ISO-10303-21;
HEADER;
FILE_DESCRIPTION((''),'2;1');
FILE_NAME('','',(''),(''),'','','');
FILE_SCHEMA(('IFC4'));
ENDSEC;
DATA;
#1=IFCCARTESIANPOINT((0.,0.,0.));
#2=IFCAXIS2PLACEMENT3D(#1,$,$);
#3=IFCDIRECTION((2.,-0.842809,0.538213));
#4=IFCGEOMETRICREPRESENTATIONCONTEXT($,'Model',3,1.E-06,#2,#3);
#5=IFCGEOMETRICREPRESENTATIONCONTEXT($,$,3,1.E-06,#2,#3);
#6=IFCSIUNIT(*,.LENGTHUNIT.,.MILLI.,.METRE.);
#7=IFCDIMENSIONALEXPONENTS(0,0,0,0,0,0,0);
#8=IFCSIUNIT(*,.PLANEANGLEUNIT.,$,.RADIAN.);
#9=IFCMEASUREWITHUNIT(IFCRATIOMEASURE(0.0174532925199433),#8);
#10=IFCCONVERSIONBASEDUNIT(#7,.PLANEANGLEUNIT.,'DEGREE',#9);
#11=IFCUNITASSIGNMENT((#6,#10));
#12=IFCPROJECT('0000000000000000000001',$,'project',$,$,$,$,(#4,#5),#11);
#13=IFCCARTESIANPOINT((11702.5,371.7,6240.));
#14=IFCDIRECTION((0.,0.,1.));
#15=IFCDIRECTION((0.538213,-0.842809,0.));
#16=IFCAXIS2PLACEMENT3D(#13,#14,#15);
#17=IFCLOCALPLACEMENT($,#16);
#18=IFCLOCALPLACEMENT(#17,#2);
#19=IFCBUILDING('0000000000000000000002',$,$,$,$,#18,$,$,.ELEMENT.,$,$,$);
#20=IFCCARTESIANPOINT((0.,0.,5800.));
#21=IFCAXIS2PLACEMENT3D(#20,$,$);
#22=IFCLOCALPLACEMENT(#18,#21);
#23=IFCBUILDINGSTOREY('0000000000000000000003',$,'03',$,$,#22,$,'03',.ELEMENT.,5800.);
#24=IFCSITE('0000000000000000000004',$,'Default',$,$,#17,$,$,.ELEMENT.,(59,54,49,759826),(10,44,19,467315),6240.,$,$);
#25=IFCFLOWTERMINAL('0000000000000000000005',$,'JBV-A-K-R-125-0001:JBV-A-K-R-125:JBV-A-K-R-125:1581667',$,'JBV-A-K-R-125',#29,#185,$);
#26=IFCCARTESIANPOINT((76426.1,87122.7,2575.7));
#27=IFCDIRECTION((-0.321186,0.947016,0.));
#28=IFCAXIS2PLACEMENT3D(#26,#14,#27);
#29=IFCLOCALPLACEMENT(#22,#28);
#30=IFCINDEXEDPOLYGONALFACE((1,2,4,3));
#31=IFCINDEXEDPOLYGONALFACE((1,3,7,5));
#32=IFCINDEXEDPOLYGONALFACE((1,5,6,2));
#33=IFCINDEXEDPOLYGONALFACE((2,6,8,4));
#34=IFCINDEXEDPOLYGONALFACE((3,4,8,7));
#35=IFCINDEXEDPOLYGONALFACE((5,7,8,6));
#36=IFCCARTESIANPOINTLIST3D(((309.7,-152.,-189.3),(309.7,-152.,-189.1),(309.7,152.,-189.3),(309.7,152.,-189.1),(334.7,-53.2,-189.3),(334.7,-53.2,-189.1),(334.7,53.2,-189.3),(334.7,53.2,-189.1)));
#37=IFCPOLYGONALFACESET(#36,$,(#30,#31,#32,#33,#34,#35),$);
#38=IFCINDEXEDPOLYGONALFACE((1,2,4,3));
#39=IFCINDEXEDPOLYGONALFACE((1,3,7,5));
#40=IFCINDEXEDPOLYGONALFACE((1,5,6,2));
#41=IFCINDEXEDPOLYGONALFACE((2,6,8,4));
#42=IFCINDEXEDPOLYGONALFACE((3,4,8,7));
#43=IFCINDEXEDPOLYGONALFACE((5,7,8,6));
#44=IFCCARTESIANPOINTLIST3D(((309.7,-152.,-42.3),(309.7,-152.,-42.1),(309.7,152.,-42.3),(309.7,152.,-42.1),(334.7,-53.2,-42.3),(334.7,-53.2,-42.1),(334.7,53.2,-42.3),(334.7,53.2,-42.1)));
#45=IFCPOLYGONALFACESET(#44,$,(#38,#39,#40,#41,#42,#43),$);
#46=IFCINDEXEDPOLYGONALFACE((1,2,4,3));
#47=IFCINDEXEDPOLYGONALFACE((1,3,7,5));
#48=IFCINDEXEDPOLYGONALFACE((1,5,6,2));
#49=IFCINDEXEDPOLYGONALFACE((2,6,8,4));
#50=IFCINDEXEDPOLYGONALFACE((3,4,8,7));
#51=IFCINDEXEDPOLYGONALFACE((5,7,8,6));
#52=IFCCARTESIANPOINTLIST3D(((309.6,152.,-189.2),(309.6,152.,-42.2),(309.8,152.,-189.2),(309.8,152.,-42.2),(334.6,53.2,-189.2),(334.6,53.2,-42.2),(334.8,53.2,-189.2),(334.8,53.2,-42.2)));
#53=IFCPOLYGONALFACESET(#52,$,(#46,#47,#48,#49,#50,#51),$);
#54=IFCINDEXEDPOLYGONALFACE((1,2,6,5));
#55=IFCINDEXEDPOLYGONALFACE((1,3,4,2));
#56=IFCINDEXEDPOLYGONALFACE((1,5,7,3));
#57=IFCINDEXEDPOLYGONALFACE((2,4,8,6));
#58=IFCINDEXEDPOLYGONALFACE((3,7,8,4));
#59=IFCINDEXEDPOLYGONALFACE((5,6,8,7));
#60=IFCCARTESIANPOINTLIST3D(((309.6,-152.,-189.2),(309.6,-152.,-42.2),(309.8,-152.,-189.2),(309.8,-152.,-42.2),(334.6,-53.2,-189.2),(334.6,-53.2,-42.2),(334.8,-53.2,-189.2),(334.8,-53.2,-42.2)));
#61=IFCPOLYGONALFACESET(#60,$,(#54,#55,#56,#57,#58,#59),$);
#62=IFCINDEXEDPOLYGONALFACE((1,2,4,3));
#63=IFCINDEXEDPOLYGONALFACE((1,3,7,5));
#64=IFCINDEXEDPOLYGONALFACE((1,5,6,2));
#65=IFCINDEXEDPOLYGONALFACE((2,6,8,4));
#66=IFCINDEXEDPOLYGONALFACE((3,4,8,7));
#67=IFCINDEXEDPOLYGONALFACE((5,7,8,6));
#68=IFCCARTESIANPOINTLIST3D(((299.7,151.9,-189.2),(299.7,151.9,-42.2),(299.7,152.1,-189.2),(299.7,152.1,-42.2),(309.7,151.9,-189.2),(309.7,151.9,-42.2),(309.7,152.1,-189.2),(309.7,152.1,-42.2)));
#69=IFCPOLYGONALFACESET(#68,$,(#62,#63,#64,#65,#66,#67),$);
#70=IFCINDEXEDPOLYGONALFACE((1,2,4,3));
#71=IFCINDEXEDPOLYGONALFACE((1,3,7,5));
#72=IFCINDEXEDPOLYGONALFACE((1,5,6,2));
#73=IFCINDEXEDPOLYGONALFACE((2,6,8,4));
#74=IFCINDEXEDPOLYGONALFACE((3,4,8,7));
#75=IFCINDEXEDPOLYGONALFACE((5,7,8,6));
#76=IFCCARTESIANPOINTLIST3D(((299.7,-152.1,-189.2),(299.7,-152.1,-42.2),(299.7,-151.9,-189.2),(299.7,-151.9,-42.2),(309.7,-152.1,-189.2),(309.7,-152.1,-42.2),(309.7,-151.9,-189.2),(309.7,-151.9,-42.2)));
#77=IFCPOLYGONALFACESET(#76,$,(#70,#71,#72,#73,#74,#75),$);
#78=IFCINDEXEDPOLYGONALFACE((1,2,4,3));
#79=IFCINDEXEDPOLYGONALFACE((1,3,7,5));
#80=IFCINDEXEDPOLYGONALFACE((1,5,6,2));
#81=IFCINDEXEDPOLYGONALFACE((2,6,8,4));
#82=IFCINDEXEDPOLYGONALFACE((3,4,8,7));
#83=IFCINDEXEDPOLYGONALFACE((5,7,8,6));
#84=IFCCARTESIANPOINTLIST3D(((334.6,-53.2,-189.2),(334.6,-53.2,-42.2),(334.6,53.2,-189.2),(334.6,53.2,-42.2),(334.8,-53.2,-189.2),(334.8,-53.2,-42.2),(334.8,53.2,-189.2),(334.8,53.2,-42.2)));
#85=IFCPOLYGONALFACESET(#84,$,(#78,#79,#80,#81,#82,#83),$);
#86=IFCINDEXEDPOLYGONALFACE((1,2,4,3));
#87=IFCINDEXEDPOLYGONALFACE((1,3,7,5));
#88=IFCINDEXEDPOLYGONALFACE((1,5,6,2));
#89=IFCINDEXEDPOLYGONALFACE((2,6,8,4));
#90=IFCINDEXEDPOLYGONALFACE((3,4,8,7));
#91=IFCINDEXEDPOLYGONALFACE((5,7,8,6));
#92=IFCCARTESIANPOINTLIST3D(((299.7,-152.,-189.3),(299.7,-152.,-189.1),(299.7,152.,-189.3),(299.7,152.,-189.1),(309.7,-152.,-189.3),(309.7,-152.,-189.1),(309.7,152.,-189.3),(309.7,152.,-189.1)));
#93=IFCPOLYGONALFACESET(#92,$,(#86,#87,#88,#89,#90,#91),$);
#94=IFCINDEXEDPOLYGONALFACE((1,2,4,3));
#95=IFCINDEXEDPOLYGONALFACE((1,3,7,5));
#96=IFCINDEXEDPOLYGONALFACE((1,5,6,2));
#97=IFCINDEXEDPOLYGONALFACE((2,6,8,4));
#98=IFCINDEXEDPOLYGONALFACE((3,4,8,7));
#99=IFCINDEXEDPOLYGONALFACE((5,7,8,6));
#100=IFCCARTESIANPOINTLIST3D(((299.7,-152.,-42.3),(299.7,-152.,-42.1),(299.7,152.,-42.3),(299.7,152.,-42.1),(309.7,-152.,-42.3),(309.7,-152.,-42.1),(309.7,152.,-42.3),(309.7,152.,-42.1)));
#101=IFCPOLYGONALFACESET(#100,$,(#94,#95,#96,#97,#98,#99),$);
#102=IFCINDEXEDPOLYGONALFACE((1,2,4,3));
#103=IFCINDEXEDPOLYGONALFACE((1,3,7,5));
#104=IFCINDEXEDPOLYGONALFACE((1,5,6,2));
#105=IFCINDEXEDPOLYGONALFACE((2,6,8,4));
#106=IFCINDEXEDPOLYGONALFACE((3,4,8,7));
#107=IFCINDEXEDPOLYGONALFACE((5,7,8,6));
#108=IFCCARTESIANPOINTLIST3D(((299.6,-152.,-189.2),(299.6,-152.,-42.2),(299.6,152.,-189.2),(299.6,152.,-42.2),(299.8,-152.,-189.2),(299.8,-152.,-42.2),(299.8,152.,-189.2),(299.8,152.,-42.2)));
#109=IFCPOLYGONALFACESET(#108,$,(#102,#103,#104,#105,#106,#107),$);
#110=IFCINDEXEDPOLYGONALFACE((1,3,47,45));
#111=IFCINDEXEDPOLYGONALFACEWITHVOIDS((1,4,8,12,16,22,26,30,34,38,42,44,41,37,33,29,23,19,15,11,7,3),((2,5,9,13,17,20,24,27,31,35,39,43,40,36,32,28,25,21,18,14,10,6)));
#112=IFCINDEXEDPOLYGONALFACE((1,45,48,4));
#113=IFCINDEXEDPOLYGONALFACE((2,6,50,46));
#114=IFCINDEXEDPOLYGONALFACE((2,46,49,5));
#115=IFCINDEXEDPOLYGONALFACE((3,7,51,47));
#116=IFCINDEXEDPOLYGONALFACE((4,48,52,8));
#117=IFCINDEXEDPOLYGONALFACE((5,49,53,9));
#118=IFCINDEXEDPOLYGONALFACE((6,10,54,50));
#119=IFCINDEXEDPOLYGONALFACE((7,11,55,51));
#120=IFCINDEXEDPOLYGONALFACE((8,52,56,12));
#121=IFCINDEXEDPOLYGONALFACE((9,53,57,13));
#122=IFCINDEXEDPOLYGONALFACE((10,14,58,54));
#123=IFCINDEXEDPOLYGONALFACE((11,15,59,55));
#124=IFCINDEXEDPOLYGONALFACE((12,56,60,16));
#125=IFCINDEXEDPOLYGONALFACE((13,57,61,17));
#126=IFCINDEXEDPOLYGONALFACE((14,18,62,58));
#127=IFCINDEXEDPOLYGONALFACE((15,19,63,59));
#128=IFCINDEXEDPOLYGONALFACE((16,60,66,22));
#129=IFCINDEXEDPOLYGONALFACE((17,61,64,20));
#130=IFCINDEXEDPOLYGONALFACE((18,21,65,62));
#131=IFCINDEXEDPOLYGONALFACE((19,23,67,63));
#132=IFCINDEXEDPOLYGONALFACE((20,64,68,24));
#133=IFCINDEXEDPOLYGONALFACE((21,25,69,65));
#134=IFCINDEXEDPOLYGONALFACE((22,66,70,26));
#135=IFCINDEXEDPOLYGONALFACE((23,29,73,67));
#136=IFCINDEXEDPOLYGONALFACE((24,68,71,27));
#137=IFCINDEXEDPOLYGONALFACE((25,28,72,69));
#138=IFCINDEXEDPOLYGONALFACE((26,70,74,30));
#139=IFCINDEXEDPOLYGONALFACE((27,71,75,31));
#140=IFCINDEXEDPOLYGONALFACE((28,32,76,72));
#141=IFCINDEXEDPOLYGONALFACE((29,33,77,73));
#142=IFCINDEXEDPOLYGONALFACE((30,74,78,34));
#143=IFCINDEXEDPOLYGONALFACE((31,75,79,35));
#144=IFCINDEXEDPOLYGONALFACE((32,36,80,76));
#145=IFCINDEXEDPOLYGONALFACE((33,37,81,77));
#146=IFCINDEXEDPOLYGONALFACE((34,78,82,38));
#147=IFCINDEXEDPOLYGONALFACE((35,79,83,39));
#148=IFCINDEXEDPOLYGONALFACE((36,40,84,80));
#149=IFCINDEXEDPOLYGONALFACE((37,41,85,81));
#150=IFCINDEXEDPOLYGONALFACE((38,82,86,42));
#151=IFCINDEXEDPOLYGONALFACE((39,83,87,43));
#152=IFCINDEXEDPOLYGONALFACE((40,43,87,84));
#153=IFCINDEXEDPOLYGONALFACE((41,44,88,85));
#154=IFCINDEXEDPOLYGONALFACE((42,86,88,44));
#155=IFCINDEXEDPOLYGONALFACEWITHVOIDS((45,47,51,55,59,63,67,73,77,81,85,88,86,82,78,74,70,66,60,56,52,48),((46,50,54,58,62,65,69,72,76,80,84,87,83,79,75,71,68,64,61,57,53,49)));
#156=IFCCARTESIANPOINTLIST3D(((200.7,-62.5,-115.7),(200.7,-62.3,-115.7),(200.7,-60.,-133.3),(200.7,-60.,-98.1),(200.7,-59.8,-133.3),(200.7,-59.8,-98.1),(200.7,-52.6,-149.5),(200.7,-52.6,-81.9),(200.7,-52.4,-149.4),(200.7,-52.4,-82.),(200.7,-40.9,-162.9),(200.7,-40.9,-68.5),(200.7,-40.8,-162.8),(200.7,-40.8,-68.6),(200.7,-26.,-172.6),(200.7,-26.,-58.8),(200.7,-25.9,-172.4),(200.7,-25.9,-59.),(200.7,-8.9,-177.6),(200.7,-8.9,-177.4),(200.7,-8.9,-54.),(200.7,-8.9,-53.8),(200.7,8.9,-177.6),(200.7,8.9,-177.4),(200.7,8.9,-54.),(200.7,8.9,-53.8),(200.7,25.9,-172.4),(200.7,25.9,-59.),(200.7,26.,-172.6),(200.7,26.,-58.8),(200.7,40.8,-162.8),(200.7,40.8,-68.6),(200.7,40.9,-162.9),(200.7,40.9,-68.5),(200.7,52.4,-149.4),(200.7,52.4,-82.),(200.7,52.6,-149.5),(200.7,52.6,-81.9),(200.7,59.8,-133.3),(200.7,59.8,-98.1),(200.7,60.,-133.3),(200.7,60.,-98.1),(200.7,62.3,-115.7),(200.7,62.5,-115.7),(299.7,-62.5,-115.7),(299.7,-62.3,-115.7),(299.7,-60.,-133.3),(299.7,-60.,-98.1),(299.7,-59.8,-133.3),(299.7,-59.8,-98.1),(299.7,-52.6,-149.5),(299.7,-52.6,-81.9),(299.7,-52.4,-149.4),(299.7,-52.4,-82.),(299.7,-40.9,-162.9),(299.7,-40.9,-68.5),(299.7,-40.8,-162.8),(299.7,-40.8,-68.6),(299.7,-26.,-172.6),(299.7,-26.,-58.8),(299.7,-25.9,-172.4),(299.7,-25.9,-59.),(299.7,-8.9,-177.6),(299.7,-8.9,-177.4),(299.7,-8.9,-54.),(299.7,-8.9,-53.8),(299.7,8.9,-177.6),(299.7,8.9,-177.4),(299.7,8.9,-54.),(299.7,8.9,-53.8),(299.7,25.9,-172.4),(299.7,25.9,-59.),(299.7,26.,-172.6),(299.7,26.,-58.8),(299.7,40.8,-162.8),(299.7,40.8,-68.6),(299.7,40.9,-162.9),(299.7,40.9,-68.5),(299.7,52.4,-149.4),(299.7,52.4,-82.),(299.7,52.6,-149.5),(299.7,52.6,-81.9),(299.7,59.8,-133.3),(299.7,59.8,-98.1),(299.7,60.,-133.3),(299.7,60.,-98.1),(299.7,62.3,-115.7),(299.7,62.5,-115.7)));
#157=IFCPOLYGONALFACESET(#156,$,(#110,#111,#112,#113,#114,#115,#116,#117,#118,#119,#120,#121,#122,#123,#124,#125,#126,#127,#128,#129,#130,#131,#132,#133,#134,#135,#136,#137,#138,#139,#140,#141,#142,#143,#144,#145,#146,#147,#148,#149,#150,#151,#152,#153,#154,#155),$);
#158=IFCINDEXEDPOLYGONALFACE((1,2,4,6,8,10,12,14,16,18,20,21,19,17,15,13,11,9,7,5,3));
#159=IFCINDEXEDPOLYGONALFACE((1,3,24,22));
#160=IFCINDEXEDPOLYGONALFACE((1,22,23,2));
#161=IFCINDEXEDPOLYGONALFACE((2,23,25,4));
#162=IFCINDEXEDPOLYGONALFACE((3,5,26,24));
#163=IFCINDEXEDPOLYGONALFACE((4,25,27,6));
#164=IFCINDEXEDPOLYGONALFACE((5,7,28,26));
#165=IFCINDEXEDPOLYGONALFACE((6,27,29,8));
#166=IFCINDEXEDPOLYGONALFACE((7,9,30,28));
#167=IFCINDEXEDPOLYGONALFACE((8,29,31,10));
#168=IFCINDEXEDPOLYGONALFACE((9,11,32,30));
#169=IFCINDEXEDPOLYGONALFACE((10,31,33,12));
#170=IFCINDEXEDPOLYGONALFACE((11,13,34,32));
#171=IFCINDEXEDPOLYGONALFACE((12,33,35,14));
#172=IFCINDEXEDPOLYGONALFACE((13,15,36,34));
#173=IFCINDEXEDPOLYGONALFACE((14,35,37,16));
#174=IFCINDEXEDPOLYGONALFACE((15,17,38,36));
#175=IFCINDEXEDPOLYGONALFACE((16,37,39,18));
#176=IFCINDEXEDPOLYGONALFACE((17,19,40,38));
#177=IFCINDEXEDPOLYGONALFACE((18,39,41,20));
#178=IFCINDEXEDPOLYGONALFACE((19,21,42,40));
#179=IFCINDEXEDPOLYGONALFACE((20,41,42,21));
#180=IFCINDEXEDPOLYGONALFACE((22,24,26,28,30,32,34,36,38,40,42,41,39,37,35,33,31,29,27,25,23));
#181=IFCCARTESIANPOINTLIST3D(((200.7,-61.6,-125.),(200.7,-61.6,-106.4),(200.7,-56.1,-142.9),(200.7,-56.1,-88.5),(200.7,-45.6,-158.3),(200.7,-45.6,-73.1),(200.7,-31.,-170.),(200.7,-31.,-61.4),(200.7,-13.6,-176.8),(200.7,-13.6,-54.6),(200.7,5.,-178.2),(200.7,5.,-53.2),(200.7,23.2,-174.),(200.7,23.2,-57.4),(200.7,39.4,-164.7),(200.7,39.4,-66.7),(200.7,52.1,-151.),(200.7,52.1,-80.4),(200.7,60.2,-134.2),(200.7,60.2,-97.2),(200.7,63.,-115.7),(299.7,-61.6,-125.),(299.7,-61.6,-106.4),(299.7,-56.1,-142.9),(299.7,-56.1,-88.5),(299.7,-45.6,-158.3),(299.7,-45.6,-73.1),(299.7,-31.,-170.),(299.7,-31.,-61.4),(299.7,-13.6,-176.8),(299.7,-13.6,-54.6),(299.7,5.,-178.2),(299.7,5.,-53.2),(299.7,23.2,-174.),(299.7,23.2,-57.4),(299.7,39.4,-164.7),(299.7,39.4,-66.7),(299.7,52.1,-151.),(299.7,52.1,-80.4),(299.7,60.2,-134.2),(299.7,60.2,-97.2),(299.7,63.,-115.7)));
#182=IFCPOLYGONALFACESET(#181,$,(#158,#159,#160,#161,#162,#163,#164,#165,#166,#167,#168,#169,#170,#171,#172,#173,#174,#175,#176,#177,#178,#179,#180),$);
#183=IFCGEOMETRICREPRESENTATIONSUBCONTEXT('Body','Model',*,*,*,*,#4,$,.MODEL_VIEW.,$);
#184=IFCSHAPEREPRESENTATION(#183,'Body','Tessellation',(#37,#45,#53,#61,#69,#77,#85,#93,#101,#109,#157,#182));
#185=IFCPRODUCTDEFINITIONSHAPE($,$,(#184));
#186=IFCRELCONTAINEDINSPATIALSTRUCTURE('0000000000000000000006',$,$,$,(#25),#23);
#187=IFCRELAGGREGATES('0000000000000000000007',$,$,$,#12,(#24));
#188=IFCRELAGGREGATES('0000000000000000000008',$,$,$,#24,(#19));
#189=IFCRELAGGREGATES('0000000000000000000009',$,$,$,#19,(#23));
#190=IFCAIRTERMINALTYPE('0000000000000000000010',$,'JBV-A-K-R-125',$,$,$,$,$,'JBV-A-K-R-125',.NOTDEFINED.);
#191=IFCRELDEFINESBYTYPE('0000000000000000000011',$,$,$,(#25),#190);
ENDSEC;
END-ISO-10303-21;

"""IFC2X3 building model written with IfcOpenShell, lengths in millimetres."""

from ifc_helpers import new_model, entity, si_unit, converted_unit, direction, frame, frame_2d, origin, origin_2d_with_axis, place, context, subcontext, project, spatial, polyline, circle_curve, parameter, trimmed, segment, composite_curve, rectangle, circle, outline, extrude, source, transform, mapped, type_object, type_shapes, element, save


model = new_model("IFC2X3")

# Units and contexts
model_context = context("Model", 3, precision=1e-06, world=origin(), true_north=direction((2.0, -0.842809, 0.538213)))
context_of_model = context(None, 3, precision=1e-06, world=origin(), true_north=direction((2.0, -0.842809, 0.538213)))
body_context = subcontext(model_context, "Body", "Model", "MODEL_VIEW")
ifc_project = project(units=[si_unit("LENGTHUNIT", "METRE", prefix="MILLI"), converted_unit("PLANEANGLEUNIT", "DEGREE", entity("IfcRatioMeasure", 0.0174532925199433), si_unit("PLANEANGLEUNIT", "RADIAN"), dimensions=[0, 0, 0, 0, 0, 0, 0])], contexts=[model_context, context_of_model])

# Site, building, storey
site_placement = place(None, frame((11702.5, 371.7, 6240.0), z_axis=(0.0, 0.0, 1.0), x_axis=(0.538213, -0.842809, 0.0)))
site = spatial("IfcSite", under=ifc_project, at=site_placement, Name="Default", CompositionType="ELEMENT", RefLatitude=(59, 54, 49, 759826), RefLongitude=(10, 44, 19, 467315), RefElevation=6240.0)
building_placement = place(site_placement, origin())
building = spatial("IfcBuilding", under=site, at=building_placement, CompositionType="ELEMENT")
storey_placement = place(building_placement, frame((0.0, 0.0, 5800.0)))
storey = spatial("IfcBuildingStorey", under=building, at=storey_placement, Name="03", LongName="03", CompositionType="ELEMENT", Elevation=5800.0)

# Flow terminal
air_terminal_type_1 = type_object("IfcAirTerminalType", Name="JBV-A-K-R-125", ElementType="JBV-A-K-R-125", PredefinedType="NOTDEFINED")
shared_shape_1 = source(origin(), body_context, "Body", "SweptSolid", [
    extrude(outline(polyline([(-152.0, -12.5), (152.0, -12.5), (53.2, 12.5), (-53.2, 12.5), (-152.0, -12.5)])), frame((322.2, 0.0, -189.3), z_axis=(0.0, 0.0, 1.0), x_axis=(0.0, -1.0, 0.0)), (0.0, 0.0, 1.0), 0.2),
    extrude(outline(polyline([(-152.0, -12.5), (152.0, -12.5), (53.2, 12.5), (-53.2, 12.5), (-152.0, -12.5)])), frame((322.2, 0.0, -42.3), z_axis=(0.0, 0.0, 1.0), x_axis=(0.0, -1.0, 0.0)), (0.0, 0.0, 1.0), 0.2),
    extrude(rectangle(XDim=0.2, YDim=101.9, at=frame_2d((0.0, 0.0), x_axis=(1.0, 0.0))), frame((322.2, 102.6, -189.2), z_axis=(0.0, 0.0, 1.0), x_axis=(0.969446, 0.245305, 0.0)), (0.0, 0.0, 1.0), 147.0),
    extrude(rectangle(XDim=0.2, YDim=101.9, at=frame_2d((0.0, 0.0), x_axis=(1.0, 0.0))), frame((322.2, -102.6, -189.2), z_axis=(0.0, 0.0, 1.0), x_axis=(-0.969446, 0.245305, 0.0)), (0.0, 0.0, 1.0), 147.0),
    extrude(rectangle(XDim=0.2, YDim=10.0, at=frame_2d((0.0, 0.0), x_axis=(1.0, 0.0))), frame((304.7, 152.0, -189.2), z_axis=(0.0, 0.0, 1.0), x_axis=(0.0, 1.0, 0.0)), (0.0, 0.0, 1.0), 147.0),
    extrude(rectangle(XDim=0.2, YDim=10.0, at=frame_2d((0.0, 0.0), x_axis=(1.0, 0.0))), frame((304.7, -152.0, -189.2), z_axis=(0.0, 0.0, 1.0), x_axis=(0.0, 1.0, 0.0)), (0.0, 0.0, 1.0), 147.0),
    extrude(rectangle(XDim=0.2, YDim=106.4, at=frame_2d((0.0, 0.0), x_axis=(1.0, 0.0))), frame((334.7, 0.0, -189.2)), (0.0, 0.0, 1.0), 147.0),
    extrude(rectangle(XDim=304.0, YDim=10.0, at=frame_2d((0.0, 0.0), x_axis=(1.0, 0.0))), frame((304.7, 0.0, -189.3), z_axis=(0.0, 0.0, 1.0), x_axis=(0.0, -1.0, 0.0)), (0.0, 0.0, 1.0), 0.2),
    extrude(rectangle(XDim=304.0, YDim=10.0, at=frame_2d((0.0, 0.0), x_axis=(1.0, 0.0))), frame((304.7, 0.0, -42.3), z_axis=(0.0, 0.0, 1.0), x_axis=(0.0, -1.0, 0.0)), (0.0, 0.0, 1.0), 0.2),
    extrude(rectangle(XDim=0.2, YDim=304.0, at=frame_2d((0.0, 0.0), x_axis=(1.0, 0.0))), frame((299.7, 0.0, -189.2)), (0.0, 0.0, 1.0), 147.0),
    extrude(outline(composite_curve([segment(trimmed(circle_curve(origin_2d_with_axis(), 62.5), [parameter(0.0)], [parameter(180.0)], True, "PARAMETER"), True, "CONTINUOUS"), segment(trimmed(circle_curve(origin_2d_with_axis(), 62.5), [parameter(180.0)], [parameter(360.0)], True, "PARAMETER"), True, "CONTINUOUS")], self_intersect=False), holes=[composite_curve([segment(trimmed(circle_curve(origin_2d_with_axis(), 62.3), [parameter(180.0)], [parameter(360.0)], True, "PARAMETER"), False, "CONTINUOUS"), segment(trimmed(circle_curve(origin_2d_with_axis(), 62.3), [parameter(0.0)], [parameter(180.0)], True, "PARAMETER"), False, "CONTINUOUS")], self_intersect=False)]), frame((200.7, 0.0, -115.7), z_axis=(1.0, 0.0, 0.0), x_axis=(0.0, 1.0, 0.0)), (0.0, 0.0, 1.0), 99.0),
    extrude(circle(Radius=62.6, at=frame_2d((0.0, 0.0), x_axis=(1.0, 0.0))), frame((200.7, 0.3, -115.7), z_axis=(1.0, 0.0, 0.0), x_axis=(0.0, 1.0, 0.0)), (0.0, 0.0, 1.0), 99.0),
])
type_shapes(air_terminal_type_1, [shared_shape_1])
flow_terminal_1_placement = place(storey_placement, frame((76426.1, 87122.7, 2575.7), z_axis=(0.0, 0.0, 1.0), x_axis=(-0.321186, 0.947016, 0.0)))
element("IfcFlowTerminal", 1, at=flow_terminal_1_placement, inside=storey, type_object=air_terminal_type_1, Name="JBV-A-K-R-125-0001:JBV-A-K-R-125:JBV-A-K-R-125:1581667", ObjectType="JBV-A-K-R-125", context=body_context, shape_type="MappedRepresentation", body=[
    mapped(shared_shape_1, transform((0.0, 0.0, 0.0), scale=1.0)),
])

save(model, "model.ifc")
